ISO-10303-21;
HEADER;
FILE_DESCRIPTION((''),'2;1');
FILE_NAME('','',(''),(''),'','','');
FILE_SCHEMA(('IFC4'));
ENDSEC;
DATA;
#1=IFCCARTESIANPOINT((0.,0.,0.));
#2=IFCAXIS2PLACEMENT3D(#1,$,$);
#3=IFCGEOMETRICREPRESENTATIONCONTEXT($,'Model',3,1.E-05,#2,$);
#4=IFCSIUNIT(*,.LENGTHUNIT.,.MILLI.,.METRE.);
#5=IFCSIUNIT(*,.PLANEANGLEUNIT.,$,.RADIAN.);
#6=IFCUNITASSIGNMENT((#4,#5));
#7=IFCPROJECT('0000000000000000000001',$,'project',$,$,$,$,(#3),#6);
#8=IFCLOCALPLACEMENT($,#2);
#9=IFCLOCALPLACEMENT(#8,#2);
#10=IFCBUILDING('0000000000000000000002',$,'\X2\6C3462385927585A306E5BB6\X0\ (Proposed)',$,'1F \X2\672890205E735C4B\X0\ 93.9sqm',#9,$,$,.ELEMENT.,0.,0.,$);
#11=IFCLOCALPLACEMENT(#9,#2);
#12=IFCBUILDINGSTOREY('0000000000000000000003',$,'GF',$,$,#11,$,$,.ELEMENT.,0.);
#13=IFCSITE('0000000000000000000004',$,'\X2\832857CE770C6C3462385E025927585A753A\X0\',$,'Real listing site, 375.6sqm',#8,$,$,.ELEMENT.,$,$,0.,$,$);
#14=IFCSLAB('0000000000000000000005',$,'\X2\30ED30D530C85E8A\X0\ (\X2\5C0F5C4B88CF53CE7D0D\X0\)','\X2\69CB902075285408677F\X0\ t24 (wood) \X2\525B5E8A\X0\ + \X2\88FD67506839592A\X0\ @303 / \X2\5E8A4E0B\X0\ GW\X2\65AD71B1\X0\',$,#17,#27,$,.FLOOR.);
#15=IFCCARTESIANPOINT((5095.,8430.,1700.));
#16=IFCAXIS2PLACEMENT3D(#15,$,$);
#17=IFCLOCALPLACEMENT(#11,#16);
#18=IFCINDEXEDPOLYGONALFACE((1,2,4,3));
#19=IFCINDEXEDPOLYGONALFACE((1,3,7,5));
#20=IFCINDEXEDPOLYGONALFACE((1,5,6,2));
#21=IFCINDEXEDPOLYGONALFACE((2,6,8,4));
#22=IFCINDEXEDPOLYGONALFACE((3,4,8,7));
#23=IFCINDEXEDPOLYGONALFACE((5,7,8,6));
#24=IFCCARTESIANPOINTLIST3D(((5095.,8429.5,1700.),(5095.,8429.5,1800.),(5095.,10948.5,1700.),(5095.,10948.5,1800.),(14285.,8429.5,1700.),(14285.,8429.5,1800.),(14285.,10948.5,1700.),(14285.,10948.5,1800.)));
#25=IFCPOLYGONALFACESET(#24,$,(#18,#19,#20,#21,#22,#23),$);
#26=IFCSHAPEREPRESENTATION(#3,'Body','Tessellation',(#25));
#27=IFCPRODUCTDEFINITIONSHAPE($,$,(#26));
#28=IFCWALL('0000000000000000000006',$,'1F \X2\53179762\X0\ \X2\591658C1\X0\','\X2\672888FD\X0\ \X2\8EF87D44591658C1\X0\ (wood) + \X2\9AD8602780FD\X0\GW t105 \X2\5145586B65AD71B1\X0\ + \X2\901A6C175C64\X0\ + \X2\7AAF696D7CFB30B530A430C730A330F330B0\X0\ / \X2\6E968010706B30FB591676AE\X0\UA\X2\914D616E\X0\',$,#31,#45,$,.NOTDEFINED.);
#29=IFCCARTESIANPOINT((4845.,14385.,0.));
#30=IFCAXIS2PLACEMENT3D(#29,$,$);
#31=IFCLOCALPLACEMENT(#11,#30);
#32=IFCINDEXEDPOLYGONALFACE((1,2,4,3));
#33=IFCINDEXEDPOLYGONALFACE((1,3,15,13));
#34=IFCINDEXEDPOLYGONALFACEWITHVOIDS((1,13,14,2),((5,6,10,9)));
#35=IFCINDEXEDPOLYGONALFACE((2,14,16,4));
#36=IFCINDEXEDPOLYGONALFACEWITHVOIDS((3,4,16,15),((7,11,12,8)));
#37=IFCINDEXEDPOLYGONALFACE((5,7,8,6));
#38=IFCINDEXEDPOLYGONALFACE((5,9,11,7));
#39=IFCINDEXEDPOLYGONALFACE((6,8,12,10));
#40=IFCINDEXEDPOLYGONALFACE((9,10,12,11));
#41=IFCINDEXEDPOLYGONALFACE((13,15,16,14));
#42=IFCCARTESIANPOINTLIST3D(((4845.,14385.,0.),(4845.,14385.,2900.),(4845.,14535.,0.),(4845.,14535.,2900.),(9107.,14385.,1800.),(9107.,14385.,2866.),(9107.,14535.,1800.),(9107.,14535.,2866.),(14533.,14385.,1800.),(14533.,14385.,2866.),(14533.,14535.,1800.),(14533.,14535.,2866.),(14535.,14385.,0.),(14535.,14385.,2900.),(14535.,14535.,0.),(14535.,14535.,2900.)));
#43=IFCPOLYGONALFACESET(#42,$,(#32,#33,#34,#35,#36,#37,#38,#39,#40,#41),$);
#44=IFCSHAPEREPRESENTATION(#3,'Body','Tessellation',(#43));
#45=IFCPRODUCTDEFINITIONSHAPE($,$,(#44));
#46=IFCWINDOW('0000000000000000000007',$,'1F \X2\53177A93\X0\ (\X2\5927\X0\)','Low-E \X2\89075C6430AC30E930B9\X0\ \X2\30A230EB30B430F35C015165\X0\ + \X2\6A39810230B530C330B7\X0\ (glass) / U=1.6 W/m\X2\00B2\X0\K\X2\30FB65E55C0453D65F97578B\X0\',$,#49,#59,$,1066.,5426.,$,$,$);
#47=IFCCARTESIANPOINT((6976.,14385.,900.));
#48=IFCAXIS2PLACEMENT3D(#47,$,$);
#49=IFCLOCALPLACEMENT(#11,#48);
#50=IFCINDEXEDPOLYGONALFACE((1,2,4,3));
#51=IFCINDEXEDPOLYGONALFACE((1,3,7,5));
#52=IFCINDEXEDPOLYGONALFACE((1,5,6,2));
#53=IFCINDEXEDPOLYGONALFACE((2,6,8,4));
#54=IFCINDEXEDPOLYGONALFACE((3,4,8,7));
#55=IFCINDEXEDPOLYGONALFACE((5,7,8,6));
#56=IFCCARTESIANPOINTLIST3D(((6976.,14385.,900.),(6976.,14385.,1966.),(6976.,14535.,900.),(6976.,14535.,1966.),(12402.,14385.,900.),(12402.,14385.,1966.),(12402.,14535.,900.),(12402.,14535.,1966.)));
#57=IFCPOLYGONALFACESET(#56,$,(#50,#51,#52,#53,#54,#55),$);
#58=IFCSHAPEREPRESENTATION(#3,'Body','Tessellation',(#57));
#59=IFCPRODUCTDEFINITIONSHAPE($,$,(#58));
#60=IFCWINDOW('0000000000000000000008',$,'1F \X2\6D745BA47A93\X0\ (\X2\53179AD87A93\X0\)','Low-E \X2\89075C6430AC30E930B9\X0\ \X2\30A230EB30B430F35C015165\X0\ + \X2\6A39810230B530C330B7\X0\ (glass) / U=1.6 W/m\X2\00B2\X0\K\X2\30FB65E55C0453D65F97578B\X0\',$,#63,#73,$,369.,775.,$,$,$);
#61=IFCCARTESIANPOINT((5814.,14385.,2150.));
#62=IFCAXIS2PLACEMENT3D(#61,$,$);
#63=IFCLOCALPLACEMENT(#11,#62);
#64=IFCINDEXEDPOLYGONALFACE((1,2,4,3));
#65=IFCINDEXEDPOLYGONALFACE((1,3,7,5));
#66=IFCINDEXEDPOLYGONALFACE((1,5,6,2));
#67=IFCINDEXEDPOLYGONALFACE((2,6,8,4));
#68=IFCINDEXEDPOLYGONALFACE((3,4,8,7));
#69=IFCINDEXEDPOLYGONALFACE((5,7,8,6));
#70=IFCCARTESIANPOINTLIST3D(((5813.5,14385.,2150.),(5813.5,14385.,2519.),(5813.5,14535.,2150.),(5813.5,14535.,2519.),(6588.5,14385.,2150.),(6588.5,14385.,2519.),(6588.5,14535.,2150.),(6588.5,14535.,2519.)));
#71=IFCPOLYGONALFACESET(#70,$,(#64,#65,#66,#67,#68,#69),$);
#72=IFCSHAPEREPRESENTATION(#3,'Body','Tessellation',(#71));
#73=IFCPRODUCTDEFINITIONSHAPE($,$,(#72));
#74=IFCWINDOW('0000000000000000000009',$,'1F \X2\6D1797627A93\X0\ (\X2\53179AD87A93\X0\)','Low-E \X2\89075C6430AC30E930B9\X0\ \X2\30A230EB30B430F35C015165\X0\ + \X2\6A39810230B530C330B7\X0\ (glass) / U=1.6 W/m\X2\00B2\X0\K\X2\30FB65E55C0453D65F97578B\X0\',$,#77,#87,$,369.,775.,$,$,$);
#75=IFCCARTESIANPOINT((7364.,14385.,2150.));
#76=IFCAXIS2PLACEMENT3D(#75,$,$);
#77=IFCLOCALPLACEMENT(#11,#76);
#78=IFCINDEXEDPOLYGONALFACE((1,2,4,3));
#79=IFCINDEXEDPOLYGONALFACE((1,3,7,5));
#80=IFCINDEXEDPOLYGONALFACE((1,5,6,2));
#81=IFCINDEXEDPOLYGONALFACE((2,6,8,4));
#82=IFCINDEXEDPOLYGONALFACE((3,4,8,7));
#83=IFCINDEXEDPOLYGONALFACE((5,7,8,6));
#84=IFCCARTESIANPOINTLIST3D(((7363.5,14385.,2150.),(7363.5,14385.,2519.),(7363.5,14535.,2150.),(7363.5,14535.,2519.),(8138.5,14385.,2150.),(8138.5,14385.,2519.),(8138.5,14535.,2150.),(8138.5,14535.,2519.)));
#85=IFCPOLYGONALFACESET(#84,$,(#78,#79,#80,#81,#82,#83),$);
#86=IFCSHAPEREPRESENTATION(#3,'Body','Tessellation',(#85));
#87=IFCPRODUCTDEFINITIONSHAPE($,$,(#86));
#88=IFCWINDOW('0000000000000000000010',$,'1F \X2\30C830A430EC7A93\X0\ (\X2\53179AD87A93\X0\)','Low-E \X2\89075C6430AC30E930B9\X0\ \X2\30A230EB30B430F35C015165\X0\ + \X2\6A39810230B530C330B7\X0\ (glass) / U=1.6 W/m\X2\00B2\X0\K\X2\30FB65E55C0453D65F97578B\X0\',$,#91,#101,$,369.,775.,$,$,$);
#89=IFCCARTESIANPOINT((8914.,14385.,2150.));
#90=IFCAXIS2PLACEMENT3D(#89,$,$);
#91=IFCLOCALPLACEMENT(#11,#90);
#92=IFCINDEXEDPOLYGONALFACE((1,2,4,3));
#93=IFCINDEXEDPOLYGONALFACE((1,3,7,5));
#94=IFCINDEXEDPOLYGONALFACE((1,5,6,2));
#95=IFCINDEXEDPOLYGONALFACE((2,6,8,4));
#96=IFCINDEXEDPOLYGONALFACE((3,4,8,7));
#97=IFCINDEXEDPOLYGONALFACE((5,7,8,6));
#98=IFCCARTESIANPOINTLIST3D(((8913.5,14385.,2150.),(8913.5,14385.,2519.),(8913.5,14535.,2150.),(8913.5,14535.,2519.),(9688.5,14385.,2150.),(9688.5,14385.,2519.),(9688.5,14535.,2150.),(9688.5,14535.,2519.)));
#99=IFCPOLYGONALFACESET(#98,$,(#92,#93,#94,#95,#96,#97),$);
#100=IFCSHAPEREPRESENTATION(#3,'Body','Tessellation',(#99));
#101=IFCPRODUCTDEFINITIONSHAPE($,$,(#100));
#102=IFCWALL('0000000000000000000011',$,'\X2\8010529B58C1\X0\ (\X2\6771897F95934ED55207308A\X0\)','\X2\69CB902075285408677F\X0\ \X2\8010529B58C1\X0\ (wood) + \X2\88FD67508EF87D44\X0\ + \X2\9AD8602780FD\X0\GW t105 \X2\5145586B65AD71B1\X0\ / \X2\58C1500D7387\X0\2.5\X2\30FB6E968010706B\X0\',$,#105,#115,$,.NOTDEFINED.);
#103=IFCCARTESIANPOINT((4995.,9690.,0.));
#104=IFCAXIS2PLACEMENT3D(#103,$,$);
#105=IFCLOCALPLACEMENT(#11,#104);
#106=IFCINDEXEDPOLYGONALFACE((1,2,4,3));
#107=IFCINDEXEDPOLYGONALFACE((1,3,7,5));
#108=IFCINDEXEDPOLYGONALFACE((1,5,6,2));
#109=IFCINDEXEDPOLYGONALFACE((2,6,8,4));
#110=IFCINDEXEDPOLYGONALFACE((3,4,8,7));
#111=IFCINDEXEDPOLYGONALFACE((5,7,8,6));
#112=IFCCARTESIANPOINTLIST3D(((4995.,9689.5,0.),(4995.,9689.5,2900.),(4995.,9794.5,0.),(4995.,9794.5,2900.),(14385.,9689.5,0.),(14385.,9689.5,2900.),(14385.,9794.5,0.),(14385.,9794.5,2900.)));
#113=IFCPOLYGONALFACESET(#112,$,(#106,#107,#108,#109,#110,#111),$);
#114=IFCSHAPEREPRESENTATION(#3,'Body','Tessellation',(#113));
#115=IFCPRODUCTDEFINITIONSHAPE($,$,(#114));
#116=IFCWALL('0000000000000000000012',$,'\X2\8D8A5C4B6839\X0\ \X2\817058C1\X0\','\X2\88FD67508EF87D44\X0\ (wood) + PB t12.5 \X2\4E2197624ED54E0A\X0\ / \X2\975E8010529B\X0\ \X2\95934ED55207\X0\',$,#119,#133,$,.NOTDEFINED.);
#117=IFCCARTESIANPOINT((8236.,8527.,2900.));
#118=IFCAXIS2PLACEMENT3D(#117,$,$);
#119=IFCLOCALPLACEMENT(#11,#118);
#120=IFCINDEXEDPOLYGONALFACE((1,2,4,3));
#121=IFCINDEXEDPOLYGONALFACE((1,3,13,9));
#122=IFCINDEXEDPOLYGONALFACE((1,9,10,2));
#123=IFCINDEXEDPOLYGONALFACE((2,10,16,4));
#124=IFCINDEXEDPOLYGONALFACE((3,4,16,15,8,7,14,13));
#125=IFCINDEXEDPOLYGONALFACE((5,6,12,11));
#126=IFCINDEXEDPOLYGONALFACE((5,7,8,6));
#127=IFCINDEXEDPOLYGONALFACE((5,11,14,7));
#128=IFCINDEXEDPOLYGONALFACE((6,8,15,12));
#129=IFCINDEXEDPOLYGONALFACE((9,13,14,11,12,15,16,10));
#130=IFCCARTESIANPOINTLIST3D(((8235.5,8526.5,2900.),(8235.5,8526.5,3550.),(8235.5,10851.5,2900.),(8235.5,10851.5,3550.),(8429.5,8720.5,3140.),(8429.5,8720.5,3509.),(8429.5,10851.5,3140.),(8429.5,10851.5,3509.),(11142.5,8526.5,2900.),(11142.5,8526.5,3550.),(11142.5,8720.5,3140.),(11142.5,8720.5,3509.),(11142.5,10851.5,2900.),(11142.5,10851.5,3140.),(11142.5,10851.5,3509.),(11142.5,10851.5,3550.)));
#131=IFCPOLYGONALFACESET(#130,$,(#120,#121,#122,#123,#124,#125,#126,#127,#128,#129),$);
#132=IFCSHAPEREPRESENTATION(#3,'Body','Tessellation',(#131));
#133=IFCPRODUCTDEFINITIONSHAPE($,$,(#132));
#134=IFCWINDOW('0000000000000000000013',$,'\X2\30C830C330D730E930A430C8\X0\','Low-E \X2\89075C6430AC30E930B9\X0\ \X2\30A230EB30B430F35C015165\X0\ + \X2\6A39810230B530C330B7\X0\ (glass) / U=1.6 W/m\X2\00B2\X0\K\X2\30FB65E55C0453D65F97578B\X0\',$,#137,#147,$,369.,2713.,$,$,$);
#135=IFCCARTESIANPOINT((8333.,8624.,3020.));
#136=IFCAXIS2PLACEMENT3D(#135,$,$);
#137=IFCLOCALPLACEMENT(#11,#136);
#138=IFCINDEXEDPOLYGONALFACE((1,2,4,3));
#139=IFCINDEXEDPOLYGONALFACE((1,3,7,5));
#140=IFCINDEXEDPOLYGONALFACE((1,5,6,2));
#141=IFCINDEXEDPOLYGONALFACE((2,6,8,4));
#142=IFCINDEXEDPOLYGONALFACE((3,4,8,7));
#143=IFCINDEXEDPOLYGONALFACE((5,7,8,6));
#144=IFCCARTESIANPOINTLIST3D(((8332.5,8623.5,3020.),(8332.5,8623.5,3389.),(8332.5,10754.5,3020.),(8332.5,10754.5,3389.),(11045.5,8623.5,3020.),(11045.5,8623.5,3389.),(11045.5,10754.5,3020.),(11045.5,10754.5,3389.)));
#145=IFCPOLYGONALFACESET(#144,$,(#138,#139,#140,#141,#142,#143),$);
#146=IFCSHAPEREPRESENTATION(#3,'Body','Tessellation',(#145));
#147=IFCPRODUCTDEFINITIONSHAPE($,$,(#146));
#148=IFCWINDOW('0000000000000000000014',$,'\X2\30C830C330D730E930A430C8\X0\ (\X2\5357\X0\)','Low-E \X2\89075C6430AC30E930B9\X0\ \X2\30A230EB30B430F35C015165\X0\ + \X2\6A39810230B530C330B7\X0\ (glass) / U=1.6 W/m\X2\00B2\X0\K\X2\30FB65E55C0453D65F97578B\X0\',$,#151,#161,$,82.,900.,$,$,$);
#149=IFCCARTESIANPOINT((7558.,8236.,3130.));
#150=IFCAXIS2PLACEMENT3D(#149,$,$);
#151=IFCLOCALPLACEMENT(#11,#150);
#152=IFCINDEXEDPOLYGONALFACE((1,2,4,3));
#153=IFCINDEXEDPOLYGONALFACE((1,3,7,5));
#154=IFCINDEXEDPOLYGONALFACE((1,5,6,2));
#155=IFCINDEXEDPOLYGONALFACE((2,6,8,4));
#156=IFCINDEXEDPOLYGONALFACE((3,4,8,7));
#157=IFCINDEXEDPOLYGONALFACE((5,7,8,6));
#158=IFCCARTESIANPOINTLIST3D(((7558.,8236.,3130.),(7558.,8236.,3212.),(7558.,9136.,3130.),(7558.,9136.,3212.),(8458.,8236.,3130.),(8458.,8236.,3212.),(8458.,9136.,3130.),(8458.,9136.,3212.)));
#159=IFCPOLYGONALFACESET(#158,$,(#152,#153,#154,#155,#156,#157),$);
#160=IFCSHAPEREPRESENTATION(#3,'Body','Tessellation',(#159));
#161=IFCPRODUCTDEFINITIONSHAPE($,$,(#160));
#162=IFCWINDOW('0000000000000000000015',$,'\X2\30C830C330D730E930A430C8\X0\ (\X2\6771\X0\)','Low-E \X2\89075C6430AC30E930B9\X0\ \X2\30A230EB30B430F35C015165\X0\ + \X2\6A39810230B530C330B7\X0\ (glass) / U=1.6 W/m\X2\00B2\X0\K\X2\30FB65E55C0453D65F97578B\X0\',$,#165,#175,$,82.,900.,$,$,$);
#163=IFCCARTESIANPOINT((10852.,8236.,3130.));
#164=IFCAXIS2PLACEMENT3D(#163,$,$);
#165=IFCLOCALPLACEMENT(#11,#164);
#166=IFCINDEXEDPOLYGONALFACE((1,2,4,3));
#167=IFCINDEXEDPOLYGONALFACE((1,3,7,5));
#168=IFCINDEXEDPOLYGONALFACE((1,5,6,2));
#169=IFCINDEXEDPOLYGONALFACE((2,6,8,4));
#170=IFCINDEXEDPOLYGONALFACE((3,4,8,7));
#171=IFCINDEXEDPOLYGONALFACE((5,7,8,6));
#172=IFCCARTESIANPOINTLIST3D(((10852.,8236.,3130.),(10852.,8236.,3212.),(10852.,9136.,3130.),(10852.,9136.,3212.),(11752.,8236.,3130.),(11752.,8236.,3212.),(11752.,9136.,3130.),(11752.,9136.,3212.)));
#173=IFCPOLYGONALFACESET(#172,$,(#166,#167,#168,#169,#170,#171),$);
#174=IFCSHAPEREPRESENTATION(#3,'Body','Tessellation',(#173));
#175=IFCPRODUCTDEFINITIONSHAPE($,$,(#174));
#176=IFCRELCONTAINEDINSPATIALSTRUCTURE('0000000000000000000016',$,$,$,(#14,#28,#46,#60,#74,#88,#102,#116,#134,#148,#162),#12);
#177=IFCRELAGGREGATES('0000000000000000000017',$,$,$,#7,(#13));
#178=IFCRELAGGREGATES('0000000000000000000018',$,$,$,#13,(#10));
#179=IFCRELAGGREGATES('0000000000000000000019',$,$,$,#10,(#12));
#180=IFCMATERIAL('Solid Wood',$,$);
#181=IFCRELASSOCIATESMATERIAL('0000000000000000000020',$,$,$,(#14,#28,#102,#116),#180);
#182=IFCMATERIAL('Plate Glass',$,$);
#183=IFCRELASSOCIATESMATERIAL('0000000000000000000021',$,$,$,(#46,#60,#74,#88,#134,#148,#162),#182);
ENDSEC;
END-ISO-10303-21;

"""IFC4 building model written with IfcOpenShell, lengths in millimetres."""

from ifc_helpers import new_model, si_unit, frame, frame_2d, origin, place, context, project, spatial, rectangle, extrude, material, element, fill, save


model = new_model("IFC4")

# Units and contexts
model_context = context("Model", 3, precision=1e-05, world=origin())
ifc_project = project(units=[si_unit("LENGTHUNIT", "METRE", prefix="MILLI"), si_unit("PLANEANGLEUNIT", "RADIAN")], contexts=[model_context])

# Site, building, storey
site_placement = place(None, origin())
site = spatial("IfcSite", under=ifc_project, at=site_placement, Name="茨城県水戸市大塚町", ObjectType="Real listing site, 375.6sqm", CompositionType="ELEMENT", RefElevation=0.0)
building_placement = place(site_placement, origin())
building = spatial("IfcBuilding", under=site, at=building_placement, Name="水戸大塚の家 (Proposed)", ObjectType="1F 木造平屋 93.9sqm", CompositionType="ELEMENT", ElevationOfRefHeight=0.0, ElevationOfTerrain=0.0)
storey_placement = place(building_placement, origin())
storey = spatial("IfcBuildingStorey", under=building, at=storey_placement, Name="GF", CompositionType="ELEMENT", Elevation=0.0)

# Slab
ifc_material_1 = material(Name="Solid Wood")
slab_placement = place(storey_placement, frame((5095.0, 8430.0, 1700.0)))
element("IfcSlab", 1, at=slab_placement, inside=storey, material=ifc_material_1, Name="ロフト床 (小屋裏収納)", Description="構造用合板 t24 (wood) 剛床 + 製材根太 @303 / 床下 GW断熱", PredefinedType="FLOOR", context=model_context, shape_type="SweptSolid", body=[
    extrude(rectangle(XDim=9190.0, YDim=2519.0, at=frame_2d((4595.0, 1259.0))), frame((5095.0, 8430.0, 1700.0)), (0.0, 0.0, 1.0), 100.0),
])

# Wall, openings, windows
wall_1_placement = place(storey_placement, frame((4845.0, 14385.0, 0.0)))
wall_1 = element("IfcWall", 2, at=wall_1_placement, inside=storey, material=ifc_material_1, Name="1F 北面 外壁", Description="木製 軸組外壁 (wood) + 高性能GW t105 充填断熱 + 通気層 + 窯業系サイディング / 準耐火・外皮UA配慮", PredefinedType="NOTDEFINED", context=model_context, shape_type="SweptSolid", body=[
    extrude(rectangle(XDim=9690.0, YDim=150.0, at=frame_2d((4845.0, 75.0))), frame((4845.0, 14385.0, 0.0)), (0.0, 0.0, 1.0), 2900.0),
])
opening_1_placement = place(storey_placement, frame((6976.0, 14385.0, 900.0)))
opening_1 = element("IfcOpeningElement", 3, at=opening_1_placement, cuts=wall_1, PredefinedType="NOTDEFINED", context=model_context, shape_type="SweptSolid", body=[
    extrude(rectangle(XDim=5426.0, YDim=150.0, at=frame_2d((2713.0, 75.0))), frame((6976.0, 14385.0, 900.0)), (0.0, 0.0, 1.0), 1066.0),
])
opening_2_placement = place(storey_placement, frame((5814.0, 14385.0, 2150.0)))
opening_2 = element("IfcOpeningElement", 4, at=opening_2_placement, cuts=wall_1, PredefinedType="NOTDEFINED", context=model_context, shape_type="SweptSolid", body=[
    extrude(rectangle(XDim=775.0, YDim=150.0, at=frame_2d((387.0, 75.0))), frame((5814.0, 14385.0, 2150.0)), (0.0, 0.0, 1.0), 369.0),
])
opening_3_placement = place(storey_placement, frame((7364.0, 14385.0, 2150.0)))
opening_3 = element("IfcOpeningElement", 5, at=opening_3_placement, cuts=wall_1, PredefinedType="NOTDEFINED", context=model_context, shape_type="SweptSolid", body=[
    extrude(rectangle(XDim=775.0, YDim=150.0, at=frame_2d((387.0, 75.0))), frame((7364.0, 14385.0, 2150.0)), (0.0, 0.0, 1.0), 369.0),
])
opening_4_placement = place(storey_placement, frame((8914.0, 14385.0, 2150.0)))
opening_4 = element("IfcOpeningElement", 6, at=opening_4_placement, cuts=wall_1, PredefinedType="NOTDEFINED", context=model_context, shape_type="SweptSolid", body=[
    extrude(rectangle(XDim=775.0, YDim=150.0, at=frame_2d((387.0, 75.0))), frame((8914.0, 14385.0, 2150.0)), (0.0, 0.0, 1.0), 369.0),
])
ifc_material_2 = material(Name="Plate Glass")
window_1_placement = place(storey_placement, frame((6976.0, 14385.0, 900.0)))
window_1 = element("IfcWindow", 7, at=window_1_placement, inside=storey, material=ifc_material_2, Name="1F 北窓 (大)", Description="Low-E 複層ガラス アルゴン封入 + 樹脂サッシ (glass) / U=1.6 W/m²K・日射取得型", OverallHeight=1066.0, OverallWidth=5426.0, context=model_context, shape_type="SweptSolid", body=[
    extrude(rectangle(XDim=5426.0, YDim=150.0, at=frame_2d((2713.0, 75.0))), frame((6976.0, 14385.0, 900.0)), (0.0, 0.0, 1.0), 1066.0),
])
fill(opening_1, window_1)
window_2_placement = place(storey_placement, frame((5814.0, 14385.0, 2150.0)))
window_2 = element("IfcWindow", 8, at=window_2_placement, inside=storey, material=ifc_material_2, Name="1F 浴室窓 (北高窓)", Description="Low-E 複層ガラス アルゴン封入 + 樹脂サッシ (glass) / U=1.6 W/m²K・日射取得型", OverallHeight=369.0, OverallWidth=775.0, context=model_context, shape_type="SweptSolid", body=[
    extrude(rectangle(XDim=775.0, YDim=150.0, at=frame_2d((387.0, 75.0))), frame((5814.0, 14385.0, 2150.0)), (0.0, 0.0, 1.0), 369.0),
])
fill(opening_2, window_2)
window_3_placement = place(storey_placement, frame((7364.0, 14385.0, 2150.0)))
window_3 = element("IfcWindow", 9, at=window_3_placement, inside=storey, material=ifc_material_2, Name="1F 洗面窓 (北高窓)", Description="Low-E 複層ガラス アルゴン封入 + 樹脂サッシ (glass) / U=1.6 W/m²K・日射取得型", OverallHeight=369.0, OverallWidth=775.0, context=model_context, shape_type="SweptSolid", body=[
    extrude(rectangle(XDim=775.0, YDim=150.0, at=frame_2d((387.0, 75.0))), frame((7364.0, 14385.0, 2150.0)), (0.0, 0.0, 1.0), 369.0),
])
fill(opening_3, window_3)
window_4_placement = place(storey_placement, frame((8914.0, 14385.0, 2150.0)))
window_4 = element("IfcWindow", 10, at=window_4_placement, inside=storey, material=ifc_material_2, Name="1F トイレ窓 (北高窓)", Description="Low-E 複層ガラス アルゴン封入 + 樹脂サッシ (glass) / U=1.6 W/m²K・日射取得型", OverallHeight=369.0, OverallWidth=775.0, context=model_context, shape_type="SweptSolid", body=[
    extrude(rectangle(XDim=775.0, YDim=150.0, at=frame_2d((387.0, 75.0))), frame((8914.0, 14385.0, 2150.0)), (0.0, 0.0, 1.0), 369.0),
])
fill(opening_4, window_4)

# Wall
wall_2_placement = place(storey_placement, frame((4995.0, 9690.0, 0.0)))
element("IfcWall", 11, at=wall_2_placement, inside=storey, material=ifc_material_1, Name="耐力壁 (東西間仕切り)", Description="構造用合板 耐力壁 (wood) + 製材軸組 + 高性能GW t105 充填断熱 / 壁倍率2.5・準耐火", PredefinedType="NOTDEFINED", context=model_context, shape_type="SweptSolid", body=[
    extrude(rectangle(XDim=9390.0, YDim=105.0, at=frame_2d((4695.0, 52.0))), frame((4995.0, 9690.0, 0.0)), (0.0, 0.0, 1.0), 2900.0),
])

# Wall, openings, windows
wall_3_placement = place(storey_placement, frame((8236.0, 8527.0, 2900.0)))
wall_3 = element("IfcWall", 12, at=wall_3_placement, inside=storey, material=ifc_material_1, Name="越屋根 腰壁", Description="製材軸組 (wood) + PB t12.5 両面仕上 / 非耐力 間仕切", PredefinedType="NOTDEFINED", context=model_context, shape_type="SweptSolid", body=[
    extrude(rectangle(XDim=2907.0, YDim=2325.0, at=frame_2d((1453.0, 1162.0))), frame((8236.0, 8527.0, 2900.0)), (0.0, 0.0, 1.0), 650.0),
])
opening_5_placement = place(storey_placement, frame((8333.0, 8624.0, 3020.0)))
opening_5 = element("IfcOpeningElement", 13, at=opening_5_placement, cuts=wall_3, PredefinedType="NOTDEFINED", context=model_context, shape_type="SweptSolid", body=[
    extrude(rectangle(XDim=2713.0, YDim=2131.0, at=frame_2d((1356.0, 1065.0))), frame((8333.0, 8624.0, 3020.0)), (0.0, 0.0, 1.0), 369.0),
])
opening_6_placement = place(storey_placement, frame((7558.0, 8236.0, 3130.0)))
opening_6 = element("IfcOpeningElement", 14, at=opening_6_placement, cuts=wall_3, PredefinedType="NOTDEFINED", context=model_context, shape_type="SweptSolid", body=[
    extrude(rectangle(XDim=900.0, YDim=900.0, at=frame_2d((450.0, 450.0))), frame((7558.0, 8236.0, 3130.0)), (0.0, 0.0, 1.0), 82.0),
])
opening_7_placement = place(storey_placement, frame((10852.0, 8236.0, 3130.0)))
opening_7 = element("IfcOpeningElement", 15, at=opening_7_placement, cuts=wall_3, PredefinedType="NOTDEFINED", context=model_context, shape_type="SweptSolid", body=[
    extrude(rectangle(XDim=900.0, YDim=900.0, at=frame_2d((450.0, 450.0))), frame((10852.0, 8236.0, 3130.0)), (0.0, 0.0, 1.0), 82.0),
])
window_5_placement = place(storey_placement, frame((8333.0, 8624.0, 3020.0)))
window_5 = element("IfcWindow", 16, at=window_5_placement, inside=storey, material=ifc_material_2, Name="トップライト", Description="Low-E 複層ガラス アルゴン封入 + 樹脂サッシ (glass) / U=1.6 W/m²K・日射取得型", OverallHeight=369.0, OverallWidth=2713.0, context=model_context, shape_type="SweptSolid", body=[
    extrude(rectangle(XDim=2713.0, YDim=2131.0, at=frame_2d((1356.0, 1065.0))), frame((8333.0, 8624.0, 3020.0)), (0.0, 0.0, 1.0), 369.0),
])
fill(opening_5, window_5)
window_6_placement = place(storey_placement, frame((7558.0, 8236.0, 3130.0)))
window_6 = element("IfcWindow", 17, at=window_6_placement, inside=storey, material=ifc_material_2, Name="トップライト (南)", Description="Low-E 複層ガラス アルゴン封入 + 樹脂サッシ (glass) / U=1.6 W/m²K・日射取得型", OverallHeight=82.0, OverallWidth=900.0, context=model_context, shape_type="SweptSolid", body=[
    extrude(rectangle(XDim=900.0, YDim=900.0, at=frame_2d((450.0, 450.0))), frame((7558.0, 8236.0, 3130.0)), (0.0, 0.0, 1.0), 82.0),
])
fill(opening_6, window_6)
window_7_placement = place(storey_placement, frame((10852.0, 8236.0, 3130.0)))
window_7 = element("IfcWindow", 18, at=window_7_placement, inside=storey, material=ifc_material_2, Name="トップライト (東)", Description="Low-E 複層ガラス アルゴン封入 + 樹脂サッシ (glass) / U=1.6 W/m²K・日射取得型", OverallHeight=82.0, OverallWidth=900.0, context=model_context, shape_type="SweptSolid", body=[
    extrude(rectangle(XDim=900.0, YDim=900.0, at=frame_2d((450.0, 450.0))), frame((10852.0, 8236.0, 3130.0)), (0.0, 0.0, 1.0), 82.0),
])
fill(opening_7, window_7)

save(model, "model.ifc")
